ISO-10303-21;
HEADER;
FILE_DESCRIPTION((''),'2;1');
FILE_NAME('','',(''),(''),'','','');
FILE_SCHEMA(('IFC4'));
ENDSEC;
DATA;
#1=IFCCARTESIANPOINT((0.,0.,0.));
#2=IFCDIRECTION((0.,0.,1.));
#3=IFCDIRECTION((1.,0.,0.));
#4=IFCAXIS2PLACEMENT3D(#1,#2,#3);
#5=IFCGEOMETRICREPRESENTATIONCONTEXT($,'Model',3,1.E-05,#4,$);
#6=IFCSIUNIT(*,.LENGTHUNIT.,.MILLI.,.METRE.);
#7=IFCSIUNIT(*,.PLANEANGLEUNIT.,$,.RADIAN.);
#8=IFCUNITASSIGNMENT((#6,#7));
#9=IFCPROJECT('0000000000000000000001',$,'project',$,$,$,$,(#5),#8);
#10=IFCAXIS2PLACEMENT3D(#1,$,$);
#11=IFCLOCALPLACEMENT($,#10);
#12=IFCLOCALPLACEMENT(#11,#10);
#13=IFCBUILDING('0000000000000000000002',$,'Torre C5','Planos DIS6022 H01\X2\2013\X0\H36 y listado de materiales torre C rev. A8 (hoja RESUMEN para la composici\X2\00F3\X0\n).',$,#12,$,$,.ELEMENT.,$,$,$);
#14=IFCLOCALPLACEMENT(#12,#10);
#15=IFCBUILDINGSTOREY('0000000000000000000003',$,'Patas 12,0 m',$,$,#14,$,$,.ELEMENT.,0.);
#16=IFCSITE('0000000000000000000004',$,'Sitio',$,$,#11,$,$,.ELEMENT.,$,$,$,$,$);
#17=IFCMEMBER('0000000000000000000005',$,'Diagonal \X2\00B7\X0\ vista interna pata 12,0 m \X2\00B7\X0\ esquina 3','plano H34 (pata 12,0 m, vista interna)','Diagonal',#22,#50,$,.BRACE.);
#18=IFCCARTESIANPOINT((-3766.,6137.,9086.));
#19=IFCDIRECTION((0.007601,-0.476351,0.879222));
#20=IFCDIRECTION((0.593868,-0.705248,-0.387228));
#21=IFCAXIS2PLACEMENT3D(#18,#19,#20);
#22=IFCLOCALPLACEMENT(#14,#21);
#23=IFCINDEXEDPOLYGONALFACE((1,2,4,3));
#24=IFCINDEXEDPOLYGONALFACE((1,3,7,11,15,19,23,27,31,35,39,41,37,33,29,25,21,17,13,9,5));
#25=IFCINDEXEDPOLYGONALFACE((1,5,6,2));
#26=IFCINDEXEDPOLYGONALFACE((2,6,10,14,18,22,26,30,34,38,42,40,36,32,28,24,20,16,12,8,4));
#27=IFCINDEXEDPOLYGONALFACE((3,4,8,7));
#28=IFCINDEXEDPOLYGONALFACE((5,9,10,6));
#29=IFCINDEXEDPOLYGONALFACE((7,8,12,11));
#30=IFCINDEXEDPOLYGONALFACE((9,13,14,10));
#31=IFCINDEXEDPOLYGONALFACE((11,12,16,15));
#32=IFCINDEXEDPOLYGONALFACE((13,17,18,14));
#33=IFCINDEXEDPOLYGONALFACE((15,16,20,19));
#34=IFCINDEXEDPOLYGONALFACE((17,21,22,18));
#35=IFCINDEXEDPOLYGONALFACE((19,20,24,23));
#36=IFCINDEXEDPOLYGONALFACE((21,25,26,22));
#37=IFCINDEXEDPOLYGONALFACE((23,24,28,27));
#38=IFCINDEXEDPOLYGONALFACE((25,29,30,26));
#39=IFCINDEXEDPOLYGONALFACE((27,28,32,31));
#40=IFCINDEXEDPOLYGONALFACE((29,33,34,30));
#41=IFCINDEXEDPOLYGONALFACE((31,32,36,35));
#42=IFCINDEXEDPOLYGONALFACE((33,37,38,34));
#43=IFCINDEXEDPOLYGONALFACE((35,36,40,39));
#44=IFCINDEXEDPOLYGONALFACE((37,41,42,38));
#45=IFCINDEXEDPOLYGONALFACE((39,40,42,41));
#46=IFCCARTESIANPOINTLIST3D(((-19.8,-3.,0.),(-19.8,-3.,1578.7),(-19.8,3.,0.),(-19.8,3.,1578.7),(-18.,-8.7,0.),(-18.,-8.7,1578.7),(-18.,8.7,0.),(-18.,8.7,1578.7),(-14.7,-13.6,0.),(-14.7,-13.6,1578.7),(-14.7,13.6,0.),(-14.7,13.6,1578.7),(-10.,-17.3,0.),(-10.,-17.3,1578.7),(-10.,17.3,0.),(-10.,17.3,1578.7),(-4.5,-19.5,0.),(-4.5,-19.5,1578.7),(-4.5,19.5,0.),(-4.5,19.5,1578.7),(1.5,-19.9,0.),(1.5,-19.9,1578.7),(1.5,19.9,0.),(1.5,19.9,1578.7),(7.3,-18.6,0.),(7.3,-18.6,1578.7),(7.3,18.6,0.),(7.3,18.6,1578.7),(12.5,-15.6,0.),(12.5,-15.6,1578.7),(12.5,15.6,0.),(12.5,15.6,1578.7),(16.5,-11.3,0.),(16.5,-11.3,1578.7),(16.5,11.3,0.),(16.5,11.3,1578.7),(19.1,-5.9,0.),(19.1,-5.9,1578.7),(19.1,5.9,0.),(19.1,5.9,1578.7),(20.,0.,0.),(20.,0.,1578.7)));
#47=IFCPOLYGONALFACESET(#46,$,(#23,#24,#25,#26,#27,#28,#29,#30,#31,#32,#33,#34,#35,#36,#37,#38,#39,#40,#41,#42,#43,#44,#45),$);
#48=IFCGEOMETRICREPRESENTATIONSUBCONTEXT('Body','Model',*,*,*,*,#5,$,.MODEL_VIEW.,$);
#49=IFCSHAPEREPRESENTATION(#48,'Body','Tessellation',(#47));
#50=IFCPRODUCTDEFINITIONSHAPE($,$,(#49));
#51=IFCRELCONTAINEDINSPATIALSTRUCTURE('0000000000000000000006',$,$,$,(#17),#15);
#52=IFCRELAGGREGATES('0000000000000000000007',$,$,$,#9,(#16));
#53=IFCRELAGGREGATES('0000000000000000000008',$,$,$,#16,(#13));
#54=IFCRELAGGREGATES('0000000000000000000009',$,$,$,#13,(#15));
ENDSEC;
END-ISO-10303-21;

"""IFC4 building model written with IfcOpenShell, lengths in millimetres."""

from ifc_helpers import new_model, si_unit, frame, origin, origin_with_axes, place, context, subcontext, project, spatial, circle, extrude, element, save


model = new_model("IFC4")

# Units and contexts
model_context = context("Model", 3, precision=1e-05, world=origin_with_axes())
body_context = subcontext(model_context, "Body", "Model", "MODEL_VIEW")
ifc_project = project(units=[si_unit("LENGTHUNIT", "METRE", prefix="MILLI"), si_unit("PLANEANGLEUNIT", "RADIAN")], contexts=[model_context])

# Site, building, storey
site_placement = place(None, origin())
site = spatial("IfcSite", under=ifc_project, at=site_placement, Name="Sitio", CompositionType="ELEMENT")
building_placement = place(site_placement, origin())
building = spatial("IfcBuilding", under=site, at=building_placement, Name="Torre C5", Description="Planos DIS6022 H01–H36 y listado de materiales torre C rev. A8 (hoja RESUMEN para la composición).", CompositionType="ELEMENT")
storey_placement = place(building_placement, origin())
storey = spatial("IfcBuildingStorey", under=building, at=storey_placement, Name="Patas 12,0 m", CompositionType="ELEMENT", Elevation=0.0)

# Member
member_1_placement = place(storey_placement, frame((-3766.0, 6137.0, 9086.0), z_axis=(0.007601, -0.476351, 0.879222), x_axis=(0.593868, -0.705248, -0.387228)))
element("IfcMember", 1, at=member_1_placement, inside=storey, Name="Diagonal · vista interna pata 12,0 m · esquina 3", Description="plano H34 (pata 12,0 m, vista interna)", ObjectType="Diagonal", PredefinedType="BRACE", context=body_context, shape_type="SweptSolid", body=[
    extrude(circle(Radius=20.0), None, (0.0, 0.0, 1.0), 1578.7),
])

save(model, "model.ifc")
